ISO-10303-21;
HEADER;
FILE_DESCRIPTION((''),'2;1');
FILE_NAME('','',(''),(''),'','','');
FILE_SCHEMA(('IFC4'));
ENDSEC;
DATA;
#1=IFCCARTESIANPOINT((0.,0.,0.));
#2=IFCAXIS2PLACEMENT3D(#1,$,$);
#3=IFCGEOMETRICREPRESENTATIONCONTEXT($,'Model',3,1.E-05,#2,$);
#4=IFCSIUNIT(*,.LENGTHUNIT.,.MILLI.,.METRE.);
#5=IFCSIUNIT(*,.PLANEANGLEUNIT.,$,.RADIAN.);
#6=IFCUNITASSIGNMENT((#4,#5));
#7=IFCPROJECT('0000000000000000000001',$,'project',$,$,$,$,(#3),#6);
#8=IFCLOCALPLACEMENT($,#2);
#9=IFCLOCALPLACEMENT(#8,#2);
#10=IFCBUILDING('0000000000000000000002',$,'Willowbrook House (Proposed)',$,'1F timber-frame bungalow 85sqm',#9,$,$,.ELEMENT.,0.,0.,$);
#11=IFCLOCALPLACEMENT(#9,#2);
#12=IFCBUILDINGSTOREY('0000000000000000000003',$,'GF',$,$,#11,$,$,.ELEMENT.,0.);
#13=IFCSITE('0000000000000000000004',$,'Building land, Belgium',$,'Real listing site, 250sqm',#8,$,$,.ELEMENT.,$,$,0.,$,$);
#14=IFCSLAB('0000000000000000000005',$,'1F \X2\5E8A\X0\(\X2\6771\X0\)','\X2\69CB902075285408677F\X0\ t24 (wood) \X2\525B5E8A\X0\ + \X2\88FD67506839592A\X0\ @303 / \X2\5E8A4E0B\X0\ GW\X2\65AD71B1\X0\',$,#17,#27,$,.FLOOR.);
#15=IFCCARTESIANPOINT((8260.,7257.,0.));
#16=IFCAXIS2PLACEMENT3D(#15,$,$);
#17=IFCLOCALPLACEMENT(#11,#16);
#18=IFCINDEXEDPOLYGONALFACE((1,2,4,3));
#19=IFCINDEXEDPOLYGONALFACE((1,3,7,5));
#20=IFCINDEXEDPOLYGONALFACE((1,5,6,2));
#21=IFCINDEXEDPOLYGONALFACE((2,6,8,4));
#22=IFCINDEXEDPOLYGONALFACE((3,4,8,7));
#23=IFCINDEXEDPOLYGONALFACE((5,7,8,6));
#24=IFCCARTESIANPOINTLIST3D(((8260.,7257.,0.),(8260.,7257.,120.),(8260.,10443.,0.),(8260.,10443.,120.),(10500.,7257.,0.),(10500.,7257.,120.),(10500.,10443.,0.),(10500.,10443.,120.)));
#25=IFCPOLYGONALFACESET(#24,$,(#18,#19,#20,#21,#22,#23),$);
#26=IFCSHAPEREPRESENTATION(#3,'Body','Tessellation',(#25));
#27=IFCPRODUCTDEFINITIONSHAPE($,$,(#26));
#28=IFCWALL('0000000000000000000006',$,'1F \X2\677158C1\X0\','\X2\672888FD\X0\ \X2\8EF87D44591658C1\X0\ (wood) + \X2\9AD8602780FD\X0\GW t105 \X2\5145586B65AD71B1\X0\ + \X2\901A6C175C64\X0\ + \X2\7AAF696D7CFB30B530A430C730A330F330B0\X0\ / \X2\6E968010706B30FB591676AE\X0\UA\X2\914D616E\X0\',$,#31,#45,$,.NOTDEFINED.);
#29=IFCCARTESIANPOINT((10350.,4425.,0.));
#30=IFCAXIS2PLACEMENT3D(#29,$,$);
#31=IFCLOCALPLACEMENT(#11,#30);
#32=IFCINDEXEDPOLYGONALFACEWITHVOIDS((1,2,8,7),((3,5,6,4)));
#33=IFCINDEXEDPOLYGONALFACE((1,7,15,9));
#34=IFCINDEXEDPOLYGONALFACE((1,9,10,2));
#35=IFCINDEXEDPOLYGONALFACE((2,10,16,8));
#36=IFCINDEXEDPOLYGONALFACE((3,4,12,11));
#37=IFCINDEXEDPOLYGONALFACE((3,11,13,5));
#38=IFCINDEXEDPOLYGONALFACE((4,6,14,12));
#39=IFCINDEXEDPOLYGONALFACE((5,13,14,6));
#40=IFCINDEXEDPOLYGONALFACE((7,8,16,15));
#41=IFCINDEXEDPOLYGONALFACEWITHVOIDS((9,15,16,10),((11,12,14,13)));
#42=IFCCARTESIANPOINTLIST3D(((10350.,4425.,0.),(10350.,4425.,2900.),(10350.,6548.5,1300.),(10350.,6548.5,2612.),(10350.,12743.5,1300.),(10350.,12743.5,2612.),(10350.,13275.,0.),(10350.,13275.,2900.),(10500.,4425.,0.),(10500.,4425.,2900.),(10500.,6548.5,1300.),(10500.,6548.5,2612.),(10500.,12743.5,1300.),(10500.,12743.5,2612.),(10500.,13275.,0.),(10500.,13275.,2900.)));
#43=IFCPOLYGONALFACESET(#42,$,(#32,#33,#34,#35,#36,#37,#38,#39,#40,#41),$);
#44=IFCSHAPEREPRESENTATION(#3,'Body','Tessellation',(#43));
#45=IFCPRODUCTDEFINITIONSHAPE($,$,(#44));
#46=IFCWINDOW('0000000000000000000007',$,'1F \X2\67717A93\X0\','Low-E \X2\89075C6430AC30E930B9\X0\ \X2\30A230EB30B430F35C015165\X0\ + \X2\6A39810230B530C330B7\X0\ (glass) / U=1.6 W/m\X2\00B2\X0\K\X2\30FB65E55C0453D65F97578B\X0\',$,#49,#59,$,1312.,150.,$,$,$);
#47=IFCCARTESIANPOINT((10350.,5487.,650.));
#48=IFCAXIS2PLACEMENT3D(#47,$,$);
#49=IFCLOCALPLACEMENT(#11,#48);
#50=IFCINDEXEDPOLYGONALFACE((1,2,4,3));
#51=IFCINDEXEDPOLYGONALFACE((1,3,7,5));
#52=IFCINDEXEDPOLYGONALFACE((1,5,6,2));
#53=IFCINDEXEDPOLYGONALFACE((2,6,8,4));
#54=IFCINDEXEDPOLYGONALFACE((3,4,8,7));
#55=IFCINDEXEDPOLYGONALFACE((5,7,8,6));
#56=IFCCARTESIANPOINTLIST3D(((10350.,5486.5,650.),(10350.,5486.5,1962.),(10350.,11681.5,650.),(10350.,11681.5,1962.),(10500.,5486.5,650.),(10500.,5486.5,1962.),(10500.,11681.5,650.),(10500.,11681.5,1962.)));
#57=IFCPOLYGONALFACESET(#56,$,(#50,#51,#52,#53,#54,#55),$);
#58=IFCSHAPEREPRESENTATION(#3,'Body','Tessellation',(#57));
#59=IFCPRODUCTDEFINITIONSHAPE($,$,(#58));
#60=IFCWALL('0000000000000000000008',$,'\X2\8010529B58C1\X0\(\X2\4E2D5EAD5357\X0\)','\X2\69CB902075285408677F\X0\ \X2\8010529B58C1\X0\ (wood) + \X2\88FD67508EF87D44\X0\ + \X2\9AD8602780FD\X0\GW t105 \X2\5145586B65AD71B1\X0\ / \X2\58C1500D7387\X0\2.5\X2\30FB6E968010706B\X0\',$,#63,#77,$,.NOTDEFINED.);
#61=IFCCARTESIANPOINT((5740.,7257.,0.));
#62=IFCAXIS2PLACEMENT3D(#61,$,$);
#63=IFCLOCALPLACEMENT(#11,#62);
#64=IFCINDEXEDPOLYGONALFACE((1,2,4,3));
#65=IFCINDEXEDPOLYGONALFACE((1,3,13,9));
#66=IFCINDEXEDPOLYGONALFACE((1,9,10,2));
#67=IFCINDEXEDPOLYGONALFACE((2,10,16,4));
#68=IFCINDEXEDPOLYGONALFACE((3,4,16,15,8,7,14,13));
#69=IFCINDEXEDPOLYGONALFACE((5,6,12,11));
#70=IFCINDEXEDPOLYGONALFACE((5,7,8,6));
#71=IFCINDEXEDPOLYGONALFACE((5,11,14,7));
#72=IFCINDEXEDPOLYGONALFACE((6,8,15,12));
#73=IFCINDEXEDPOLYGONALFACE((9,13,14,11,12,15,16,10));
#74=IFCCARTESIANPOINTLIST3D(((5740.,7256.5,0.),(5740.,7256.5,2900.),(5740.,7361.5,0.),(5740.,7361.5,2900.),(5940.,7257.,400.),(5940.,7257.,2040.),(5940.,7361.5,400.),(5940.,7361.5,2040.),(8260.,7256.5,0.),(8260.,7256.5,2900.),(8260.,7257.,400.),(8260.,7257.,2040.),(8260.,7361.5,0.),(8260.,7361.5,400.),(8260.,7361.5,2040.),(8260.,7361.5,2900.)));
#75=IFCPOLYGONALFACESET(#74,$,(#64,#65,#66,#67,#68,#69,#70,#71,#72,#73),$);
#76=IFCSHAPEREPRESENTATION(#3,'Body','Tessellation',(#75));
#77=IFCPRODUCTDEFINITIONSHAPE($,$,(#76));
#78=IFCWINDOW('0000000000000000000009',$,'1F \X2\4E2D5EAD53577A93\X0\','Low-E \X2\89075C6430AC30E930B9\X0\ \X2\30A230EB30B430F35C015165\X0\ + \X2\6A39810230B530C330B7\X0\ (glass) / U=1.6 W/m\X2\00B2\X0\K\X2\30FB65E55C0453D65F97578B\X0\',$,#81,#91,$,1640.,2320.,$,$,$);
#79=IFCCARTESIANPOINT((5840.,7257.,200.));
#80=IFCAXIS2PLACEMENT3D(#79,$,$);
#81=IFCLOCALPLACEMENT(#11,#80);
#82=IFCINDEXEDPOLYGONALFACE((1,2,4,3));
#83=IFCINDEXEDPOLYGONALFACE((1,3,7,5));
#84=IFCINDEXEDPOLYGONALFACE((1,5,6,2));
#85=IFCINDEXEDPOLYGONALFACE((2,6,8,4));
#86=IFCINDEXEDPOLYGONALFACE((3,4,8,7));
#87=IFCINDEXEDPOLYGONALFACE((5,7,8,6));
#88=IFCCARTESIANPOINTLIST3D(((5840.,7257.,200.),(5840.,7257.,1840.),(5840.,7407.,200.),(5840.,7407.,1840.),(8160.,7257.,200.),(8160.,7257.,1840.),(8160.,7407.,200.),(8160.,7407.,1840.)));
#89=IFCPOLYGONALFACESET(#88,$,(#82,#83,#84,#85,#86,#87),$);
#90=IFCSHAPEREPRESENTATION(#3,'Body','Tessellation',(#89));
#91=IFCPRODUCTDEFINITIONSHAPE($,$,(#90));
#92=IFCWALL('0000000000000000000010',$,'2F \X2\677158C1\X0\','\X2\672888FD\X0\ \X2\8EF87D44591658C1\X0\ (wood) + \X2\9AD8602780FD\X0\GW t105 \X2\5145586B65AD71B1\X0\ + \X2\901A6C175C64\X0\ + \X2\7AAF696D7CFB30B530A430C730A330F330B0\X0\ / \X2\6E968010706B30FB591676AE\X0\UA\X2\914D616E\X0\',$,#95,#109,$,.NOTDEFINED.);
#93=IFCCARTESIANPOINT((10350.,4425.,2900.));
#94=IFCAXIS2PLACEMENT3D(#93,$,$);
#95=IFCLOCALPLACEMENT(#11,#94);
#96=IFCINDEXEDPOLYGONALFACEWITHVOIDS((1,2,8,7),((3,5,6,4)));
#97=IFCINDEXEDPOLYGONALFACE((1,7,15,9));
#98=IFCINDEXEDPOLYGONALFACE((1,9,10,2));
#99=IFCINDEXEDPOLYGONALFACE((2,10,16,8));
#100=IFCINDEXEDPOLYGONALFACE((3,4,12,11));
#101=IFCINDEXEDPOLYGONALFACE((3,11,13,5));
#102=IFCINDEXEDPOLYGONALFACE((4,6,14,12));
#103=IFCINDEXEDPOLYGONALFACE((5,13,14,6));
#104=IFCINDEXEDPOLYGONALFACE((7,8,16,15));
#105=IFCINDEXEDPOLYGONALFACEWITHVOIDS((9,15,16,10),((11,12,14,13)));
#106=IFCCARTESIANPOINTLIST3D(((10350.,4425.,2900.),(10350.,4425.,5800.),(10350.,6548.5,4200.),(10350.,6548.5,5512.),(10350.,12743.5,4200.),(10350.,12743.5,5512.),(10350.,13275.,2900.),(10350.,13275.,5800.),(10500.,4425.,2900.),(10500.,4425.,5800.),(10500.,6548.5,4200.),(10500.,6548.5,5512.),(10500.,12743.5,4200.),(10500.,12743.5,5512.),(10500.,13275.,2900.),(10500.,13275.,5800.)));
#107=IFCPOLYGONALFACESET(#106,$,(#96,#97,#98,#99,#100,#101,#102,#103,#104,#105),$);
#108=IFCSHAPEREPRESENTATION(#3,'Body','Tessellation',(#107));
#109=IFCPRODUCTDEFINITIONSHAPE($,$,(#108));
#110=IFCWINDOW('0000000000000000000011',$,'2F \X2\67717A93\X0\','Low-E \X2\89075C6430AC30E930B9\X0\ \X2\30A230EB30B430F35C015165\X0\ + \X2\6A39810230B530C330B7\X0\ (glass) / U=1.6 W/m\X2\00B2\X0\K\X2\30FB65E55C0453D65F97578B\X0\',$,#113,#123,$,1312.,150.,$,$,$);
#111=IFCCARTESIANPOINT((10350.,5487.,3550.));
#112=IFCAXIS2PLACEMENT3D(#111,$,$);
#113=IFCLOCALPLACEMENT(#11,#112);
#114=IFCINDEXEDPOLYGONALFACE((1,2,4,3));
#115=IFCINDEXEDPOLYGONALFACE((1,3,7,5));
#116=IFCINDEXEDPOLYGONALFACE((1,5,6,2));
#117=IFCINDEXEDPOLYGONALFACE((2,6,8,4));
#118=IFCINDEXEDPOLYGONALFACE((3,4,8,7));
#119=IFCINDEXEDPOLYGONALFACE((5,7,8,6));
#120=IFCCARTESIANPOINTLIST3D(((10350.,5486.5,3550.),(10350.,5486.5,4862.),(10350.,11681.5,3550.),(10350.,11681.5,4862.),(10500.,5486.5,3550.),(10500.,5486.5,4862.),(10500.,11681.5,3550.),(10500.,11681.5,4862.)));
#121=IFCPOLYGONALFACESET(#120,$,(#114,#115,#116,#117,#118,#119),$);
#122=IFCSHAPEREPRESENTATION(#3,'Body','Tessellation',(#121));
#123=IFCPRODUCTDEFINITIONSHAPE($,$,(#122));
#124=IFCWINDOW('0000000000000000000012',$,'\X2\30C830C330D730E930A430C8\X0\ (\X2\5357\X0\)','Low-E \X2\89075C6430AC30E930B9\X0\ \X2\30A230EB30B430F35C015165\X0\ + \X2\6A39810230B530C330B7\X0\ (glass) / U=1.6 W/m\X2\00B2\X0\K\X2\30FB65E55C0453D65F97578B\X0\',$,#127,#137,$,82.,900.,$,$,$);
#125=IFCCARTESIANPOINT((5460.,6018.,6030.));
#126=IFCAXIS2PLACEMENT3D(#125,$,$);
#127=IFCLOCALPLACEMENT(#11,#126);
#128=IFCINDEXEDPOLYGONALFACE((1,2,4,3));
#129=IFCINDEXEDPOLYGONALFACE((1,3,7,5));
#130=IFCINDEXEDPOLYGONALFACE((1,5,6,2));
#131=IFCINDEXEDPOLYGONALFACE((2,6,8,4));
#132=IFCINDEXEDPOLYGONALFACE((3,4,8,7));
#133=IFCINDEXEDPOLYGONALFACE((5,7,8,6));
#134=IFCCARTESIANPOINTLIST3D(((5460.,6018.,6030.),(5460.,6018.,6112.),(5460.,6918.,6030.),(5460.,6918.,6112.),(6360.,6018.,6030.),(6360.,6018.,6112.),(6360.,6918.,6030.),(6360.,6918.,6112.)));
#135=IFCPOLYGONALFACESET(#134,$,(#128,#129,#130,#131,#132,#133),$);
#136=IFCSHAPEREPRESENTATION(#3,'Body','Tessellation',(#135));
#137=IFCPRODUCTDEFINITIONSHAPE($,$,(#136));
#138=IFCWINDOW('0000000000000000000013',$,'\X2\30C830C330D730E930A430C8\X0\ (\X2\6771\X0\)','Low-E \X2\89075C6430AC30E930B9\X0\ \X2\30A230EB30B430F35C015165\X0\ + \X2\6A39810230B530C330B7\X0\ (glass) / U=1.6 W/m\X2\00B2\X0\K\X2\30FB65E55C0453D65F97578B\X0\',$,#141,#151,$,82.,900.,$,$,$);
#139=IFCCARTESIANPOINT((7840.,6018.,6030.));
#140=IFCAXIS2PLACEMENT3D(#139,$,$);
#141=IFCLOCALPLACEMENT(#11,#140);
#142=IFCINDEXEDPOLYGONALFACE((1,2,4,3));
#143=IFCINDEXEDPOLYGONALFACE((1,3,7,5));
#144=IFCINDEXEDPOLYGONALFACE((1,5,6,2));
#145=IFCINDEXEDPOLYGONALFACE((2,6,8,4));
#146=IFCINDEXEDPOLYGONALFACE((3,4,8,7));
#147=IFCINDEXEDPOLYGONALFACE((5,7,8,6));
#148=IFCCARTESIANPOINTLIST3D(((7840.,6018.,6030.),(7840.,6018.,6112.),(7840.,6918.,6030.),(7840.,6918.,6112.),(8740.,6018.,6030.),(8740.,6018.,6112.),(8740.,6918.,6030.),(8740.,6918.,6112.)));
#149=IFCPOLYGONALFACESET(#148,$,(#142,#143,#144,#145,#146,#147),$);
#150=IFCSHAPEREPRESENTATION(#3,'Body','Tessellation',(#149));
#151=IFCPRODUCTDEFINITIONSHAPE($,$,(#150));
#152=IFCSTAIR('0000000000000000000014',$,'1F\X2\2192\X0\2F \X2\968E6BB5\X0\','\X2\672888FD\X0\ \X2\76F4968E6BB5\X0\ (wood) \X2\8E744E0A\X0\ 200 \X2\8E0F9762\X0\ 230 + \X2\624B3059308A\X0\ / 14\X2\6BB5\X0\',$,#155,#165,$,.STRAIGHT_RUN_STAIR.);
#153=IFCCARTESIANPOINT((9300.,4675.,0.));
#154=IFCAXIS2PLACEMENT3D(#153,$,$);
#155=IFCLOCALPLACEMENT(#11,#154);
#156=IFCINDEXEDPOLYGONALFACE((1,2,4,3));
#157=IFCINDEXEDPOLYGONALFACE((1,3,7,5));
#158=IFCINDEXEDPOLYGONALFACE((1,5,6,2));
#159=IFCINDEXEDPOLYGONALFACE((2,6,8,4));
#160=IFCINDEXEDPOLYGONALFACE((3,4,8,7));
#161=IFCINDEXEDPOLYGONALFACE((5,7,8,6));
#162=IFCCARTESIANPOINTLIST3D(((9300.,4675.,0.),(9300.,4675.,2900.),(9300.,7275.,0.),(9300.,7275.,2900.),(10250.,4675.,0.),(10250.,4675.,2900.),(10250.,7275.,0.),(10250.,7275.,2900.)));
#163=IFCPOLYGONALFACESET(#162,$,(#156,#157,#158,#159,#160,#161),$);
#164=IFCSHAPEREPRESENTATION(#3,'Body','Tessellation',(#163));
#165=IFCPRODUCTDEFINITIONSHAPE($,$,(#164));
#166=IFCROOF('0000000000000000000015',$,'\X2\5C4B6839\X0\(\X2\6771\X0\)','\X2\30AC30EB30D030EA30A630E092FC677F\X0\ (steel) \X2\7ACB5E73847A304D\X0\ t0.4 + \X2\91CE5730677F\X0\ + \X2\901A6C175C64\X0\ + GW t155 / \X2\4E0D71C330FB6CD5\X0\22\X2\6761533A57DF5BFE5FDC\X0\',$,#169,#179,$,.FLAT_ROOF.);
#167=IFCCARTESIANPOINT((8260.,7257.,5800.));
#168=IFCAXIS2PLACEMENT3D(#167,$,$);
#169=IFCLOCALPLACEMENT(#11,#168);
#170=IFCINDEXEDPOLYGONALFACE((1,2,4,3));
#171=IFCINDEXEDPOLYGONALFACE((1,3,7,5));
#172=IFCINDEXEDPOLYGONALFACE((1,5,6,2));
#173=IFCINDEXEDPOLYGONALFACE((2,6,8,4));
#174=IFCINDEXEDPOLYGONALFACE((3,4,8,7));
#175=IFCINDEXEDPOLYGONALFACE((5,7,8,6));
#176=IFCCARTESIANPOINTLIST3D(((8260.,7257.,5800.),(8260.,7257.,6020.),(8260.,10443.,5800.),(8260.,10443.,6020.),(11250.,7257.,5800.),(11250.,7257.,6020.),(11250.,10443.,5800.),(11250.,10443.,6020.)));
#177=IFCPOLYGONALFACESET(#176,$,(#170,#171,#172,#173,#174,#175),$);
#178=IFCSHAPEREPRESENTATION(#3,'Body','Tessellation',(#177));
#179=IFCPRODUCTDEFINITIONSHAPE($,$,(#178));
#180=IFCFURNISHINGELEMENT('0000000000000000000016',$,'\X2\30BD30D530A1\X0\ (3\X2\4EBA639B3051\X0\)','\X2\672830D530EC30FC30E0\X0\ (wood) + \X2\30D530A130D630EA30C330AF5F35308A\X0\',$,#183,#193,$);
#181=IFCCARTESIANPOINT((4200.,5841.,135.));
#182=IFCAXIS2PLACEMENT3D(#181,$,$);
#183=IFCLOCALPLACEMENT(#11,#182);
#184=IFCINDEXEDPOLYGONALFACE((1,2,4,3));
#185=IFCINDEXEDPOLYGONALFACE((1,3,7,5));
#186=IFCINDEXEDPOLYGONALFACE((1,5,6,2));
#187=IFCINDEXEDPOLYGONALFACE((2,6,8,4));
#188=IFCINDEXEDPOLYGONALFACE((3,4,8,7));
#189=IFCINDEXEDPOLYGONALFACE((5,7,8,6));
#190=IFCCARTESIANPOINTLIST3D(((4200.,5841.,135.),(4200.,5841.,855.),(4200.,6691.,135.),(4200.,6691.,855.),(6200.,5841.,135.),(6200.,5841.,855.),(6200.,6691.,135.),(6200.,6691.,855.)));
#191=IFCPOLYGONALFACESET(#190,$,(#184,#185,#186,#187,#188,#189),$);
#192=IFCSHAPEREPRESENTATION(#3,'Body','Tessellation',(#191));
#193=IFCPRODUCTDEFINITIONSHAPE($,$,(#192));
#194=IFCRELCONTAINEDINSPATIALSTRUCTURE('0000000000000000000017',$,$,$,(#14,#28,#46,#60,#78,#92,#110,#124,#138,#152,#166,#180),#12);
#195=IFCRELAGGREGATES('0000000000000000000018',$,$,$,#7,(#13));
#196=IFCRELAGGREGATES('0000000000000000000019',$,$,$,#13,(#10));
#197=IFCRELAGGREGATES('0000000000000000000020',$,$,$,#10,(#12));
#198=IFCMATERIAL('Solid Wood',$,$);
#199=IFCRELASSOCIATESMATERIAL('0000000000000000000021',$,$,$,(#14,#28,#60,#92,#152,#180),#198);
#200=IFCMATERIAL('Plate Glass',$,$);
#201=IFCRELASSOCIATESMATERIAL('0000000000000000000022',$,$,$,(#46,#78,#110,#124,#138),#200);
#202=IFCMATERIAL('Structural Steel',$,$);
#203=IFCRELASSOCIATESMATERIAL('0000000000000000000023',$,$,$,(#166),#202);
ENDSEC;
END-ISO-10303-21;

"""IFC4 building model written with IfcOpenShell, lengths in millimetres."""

from ifc_helpers import new_model, si_unit, frame, frame_2d, origin, place, context, project, spatial, rectangle, extrude, material, element, fill, save


model = new_model("IFC4")

# Units and contexts
model_context = context("Model", 3, precision=1e-05, world=origin())
ifc_project = project(units=[si_unit("LENGTHUNIT", "METRE", prefix="MILLI"), si_unit("PLANEANGLEUNIT", "RADIAN")], contexts=[model_context])

# Site, building, storey
site_placement = place(None, origin())
site = spatial("IfcSite", under=ifc_project, at=site_placement, Name="Building land, Belgium", ObjectType="Real listing site, 250sqm", CompositionType="ELEMENT", RefElevation=0.0)
building_placement = place(site_placement, origin())
building = spatial("IfcBuilding", under=site, at=building_placement, Name="Willowbrook House (Proposed)", ObjectType="1F timber-frame bungalow 85sqm", CompositionType="ELEMENT", ElevationOfRefHeight=0.0, ElevationOfTerrain=0.0)
storey_placement = place(building_placement, origin())
storey = spatial("IfcBuildingStorey", under=building, at=storey_placement, Name="GF", CompositionType="ELEMENT", Elevation=0.0)

# Slab
ifc_material_1 = material(Name="Solid Wood")
slab_placement = place(storey_placement, frame((8260.0, 7257.0, 0.0)))
element("IfcSlab", 1, at=slab_placement, inside=storey, material=ifc_material_1, Name="1F 床(東)", Description="構造用合板 t24 (wood) 剛床 + 製材根太 @303 / 床下 GW断熱", PredefinedType="FLOOR", context=model_context, shape_type="SweptSolid", body=[
    extrude(rectangle(XDim=2240.0, YDim=3186.0, at=frame_2d((1120.0, 1593.0))), frame((8260.0, 7257.0, 0.0)), (0.0, 0.0, 1.0), 120.0),
])

# Walls, openings, windows
wall_1_placement = place(storey_placement, frame((10350.0, 4425.0, 0.0)))
wall_1 = element("IfcWall", 2, at=wall_1_placement, inside=storey, material=ifc_material_1, Name="1F 東壁", Description="木製 軸組外壁 (wood) + 高性能GW t105 充填断熱 + 通気層 + 窯業系サイディング / 準耐火・外皮UA配慮", PredefinedType="NOTDEFINED", context=model_context, shape_type="SweptSolid", body=[
    extrude(rectangle(XDim=150.0, YDim=8850.0, at=frame_2d((75.0, 4425.0))), frame((10350.0, 4425.0, 0.0)), (0.0, 0.0, 1.0), 2900.0),
])
opening_1_placement = place(storey_placement, frame((10350.0, 5487.0, 650.0)))
opening_1 = element("IfcOpeningElement", 3, at=opening_1_placement, cuts=wall_1, PredefinedType="NOTDEFINED", context=model_context, shape_type="SweptSolid", body=[
    extrude(rectangle(XDim=150.0, YDim=6195.0, at=frame_2d((75.0, 3097.0))), frame((10350.0, 5487.0, 650.0)), (0.0, 0.0, 1.0), 1312.0),
])
ifc_material_2 = material(Name="Plate Glass")
window_1_placement = place(storey_placement, frame((10350.0, 5487.0, 650.0)))
window_1 = element("IfcWindow", 4, at=window_1_placement, inside=storey, material=ifc_material_2, Name="1F 東窓", Description="Low-E 複層ガラス アルゴン封入 + 樹脂サッシ (glass) / U=1.6 W/m²K・日射取得型", OverallHeight=1312.0, OverallWidth=150.0, context=model_context, shape_type="SweptSolid", body=[
    extrude(rectangle(XDim=150.0, YDim=6195.0, at=frame_2d((75.0, 3097.0))), frame((10350.0, 5487.0, 650.0)), (0.0, 0.0, 1.0), 1312.0),
])
fill(opening_1, window_1)
wall_2_placement = place(storey_placement, frame((5740.0, 7257.0, 0.0)))
wall_2 = element("IfcWall", 5, at=wall_2_placement, inside=storey, material=ifc_material_1, Name="耐力壁(中庭南)", Description="構造用合板 耐力壁 (wood) + 製材軸組 + 高性能GW t105 充填断熱 / 壁倍率2.5・準耐火", PredefinedType="NOTDEFINED", context=model_context, shape_type="SweptSolid", body=[
    extrude(rectangle(XDim=2520.0, YDim=105.0, at=frame_2d((1260.0, 52.0))), frame((5740.0, 7257.0, 0.0)), (0.0, 0.0, 1.0), 2900.0),
])
opening_2_placement = place(storey_placement, frame((5840.0, 7257.0, 200.0)))
opening_2 = element("IfcOpeningElement", 6, at=opening_2_placement, cuts=wall_2, PredefinedType="NOTDEFINED", context=model_context, shape_type="SweptSolid", body=[
    extrude(rectangle(XDim=2320.0, YDim=150.0, at=frame_2d((1160.0, 75.0))), frame((5840.0, 7257.0, 200.0)), (0.0, 0.0, 1.0), 1640.0),
])
window_2_placement = place(storey_placement, frame((5840.0, 7257.0, 200.0)))
window_2 = element("IfcWindow", 7, at=window_2_placement, inside=storey, material=ifc_material_2, Name="1F 中庭南窓", Description="Low-E 複層ガラス アルゴン封入 + 樹脂サッシ (glass) / U=1.6 W/m²K・日射取得型", OverallHeight=1640.0, OverallWidth=2320.0, context=model_context, shape_type="SweptSolid", body=[
    extrude(rectangle(XDim=2320.0, YDim=150.0, at=frame_2d((1160.0, 75.0))), frame((5840.0, 7257.0, 200.0)), (0.0, 0.0, 1.0), 1640.0),
])
fill(opening_2, window_2)

# Wall, opening, window
wall_3_placement = place(storey_placement, frame((10350.0, 4425.0, 2900.0)))
wall_3 = element("IfcWall", 8, at=wall_3_placement, inside=storey, material=ifc_material_1, Name="2F 東壁", Description="木製 軸組外壁 (wood) + 高性能GW t105 充填断熱 + 通気層 + 窯業系サイディング / 準耐火・外皮UA配慮", PredefinedType="NOTDEFINED", context=model_context, shape_type="SweptSolid", body=[
    extrude(rectangle(XDim=150.0, YDim=8850.0, at=frame_2d((75.0, 4425.0))), frame((10350.0, 4425.0, 2900.0)), (0.0, 0.0, 1.0), 2900.0),
])
opening_3_placement = place(storey_placement, frame((10350.0, 5487.0, 3550.0)))
opening_3 = element("IfcOpeningElement", 9, at=opening_3_placement, cuts=wall_3, PredefinedType="NOTDEFINED", context=model_context, shape_type="SweptSolid", body=[
    extrude(rectangle(XDim=150.0, YDim=6195.0, at=frame_2d((75.0, 3097.0))), frame((10350.0, 5487.0, 3550.0)), (0.0, 0.0, 1.0), 1312.0),
])
window_3_placement = place(storey_placement, frame((10350.0, 5487.0, 3550.0)))
window_3 = element("IfcWindow", 10, at=window_3_placement, inside=storey, material=ifc_material_2, Name="2F 東窓", Description="Low-E 複層ガラス アルゴン封入 + 樹脂サッシ (glass) / U=1.6 W/m²K・日射取得型", OverallHeight=1312.0, OverallWidth=150.0, context=model_context, shape_type="SweptSolid", body=[
    extrude(rectangle(XDim=150.0, YDim=6195.0, at=frame_2d((75.0, 3097.0))), frame((10350.0, 5487.0, 3550.0)), (0.0, 0.0, 1.0), 1312.0),
])
fill(opening_3, window_3)

# Windows
window_4_placement = place(storey_placement, frame((5460.0, 6018.0, 6030.0)))
element("IfcWindow", 11, at=window_4_placement, inside=storey, material=ifc_material_2, Name="トップライト (南)", Description="Low-E 複層ガラス アルゴン封入 + 樹脂サッシ (glass) / U=1.6 W/m²K・日射取得型", OverallHeight=82.0, OverallWidth=900.0, context=model_context, shape_type="SweptSolid", body=[
    extrude(rectangle(XDim=900.0, YDim=900.0, at=frame_2d((450.0, 450.0))), frame((5460.0, 6018.0, 6030.0)), (0.0, 0.0, 1.0), 82.0),
])
window_5_placement = place(storey_placement, frame((7840.0, 6018.0, 6030.0)))
element("IfcWindow", 12, at=window_5_placement, inside=storey, material=ifc_material_2, Name="トップライト (東)", Description="Low-E 複層ガラス アルゴン封入 + 樹脂サッシ (glass) / U=1.6 W/m²K・日射取得型", OverallHeight=82.0, OverallWidth=900.0, context=model_context, shape_type="SweptSolid", body=[
    extrude(rectangle(XDim=900.0, YDim=900.0, at=frame_2d((450.0, 450.0))), frame((7840.0, 6018.0, 6030.0)), (0.0, 0.0, 1.0), 82.0),
])

# Stair
stair_placement = place(storey_placement, frame((9300.0, 4675.0, 0.0)))
element("IfcStair", 13, at=stair_placement, inside=storey, material=ifc_material_1, Name="1F→2F 階段", Description="木製 直階段 (wood) 蹴上 200 踏面 230 + 手すり / 14段", PredefinedType="STRAIGHT_RUN_STAIR", context=model_context, shape_type="SweptSolid", body=[
    extrude(rectangle(XDim=950.0, YDim=2600.0, at=frame_2d((475.0, 1300.0))), frame((9300.0, 4675.0, 0.0)), (0.0, 0.0, 1.0), 2900.0),
])

# Roof
ifc_material_3 = material(Name="Structural Steel")
roof_placement = place(storey_placement, frame((8260.0, 7257.0, 5800.0)))
element("IfcRoof", 14, at=roof_placement, inside=storey, material=ifc_material_3, Name="屋根(東)", Description="ガルバリウム鋼板 (steel) 立平葺き t0.4 + 野地板 + 通気層 + GW t155 / 不燃・法22条区域対応", PredefinedType="FLAT_ROOF", context=model_context, shape_type="SweptSolid", body=[
    extrude(rectangle(XDim=2990.0, YDim=3186.0, at=frame_2d((1495.0, 1593.0))), frame((8260.0, 7257.0, 5800.0)), (0.0, 0.0, 1.0), 220.0),
])

# Furnishing element
furnishing_1_placement = place(storey_placement, frame((4200.0, 5841.0, 135.0)))
element("IfcFurnishingElement", 15, at=furnishing_1_placement, inside=storey, material=ifc_material_1, Name="ソファ (3人掛け)", Description="木フレーム (wood) + ファブリック張り", context=model_context, shape_type="SweptSolid", body=[
    extrude(rectangle(XDim=2000.0, YDim=850.0, at=frame_2d((1000.0, 425.0))), frame((4200.0, 5841.0, 135.0)), (0.0, 0.0, 1.0), 720.0),
])

save(model, "model.ifc")
